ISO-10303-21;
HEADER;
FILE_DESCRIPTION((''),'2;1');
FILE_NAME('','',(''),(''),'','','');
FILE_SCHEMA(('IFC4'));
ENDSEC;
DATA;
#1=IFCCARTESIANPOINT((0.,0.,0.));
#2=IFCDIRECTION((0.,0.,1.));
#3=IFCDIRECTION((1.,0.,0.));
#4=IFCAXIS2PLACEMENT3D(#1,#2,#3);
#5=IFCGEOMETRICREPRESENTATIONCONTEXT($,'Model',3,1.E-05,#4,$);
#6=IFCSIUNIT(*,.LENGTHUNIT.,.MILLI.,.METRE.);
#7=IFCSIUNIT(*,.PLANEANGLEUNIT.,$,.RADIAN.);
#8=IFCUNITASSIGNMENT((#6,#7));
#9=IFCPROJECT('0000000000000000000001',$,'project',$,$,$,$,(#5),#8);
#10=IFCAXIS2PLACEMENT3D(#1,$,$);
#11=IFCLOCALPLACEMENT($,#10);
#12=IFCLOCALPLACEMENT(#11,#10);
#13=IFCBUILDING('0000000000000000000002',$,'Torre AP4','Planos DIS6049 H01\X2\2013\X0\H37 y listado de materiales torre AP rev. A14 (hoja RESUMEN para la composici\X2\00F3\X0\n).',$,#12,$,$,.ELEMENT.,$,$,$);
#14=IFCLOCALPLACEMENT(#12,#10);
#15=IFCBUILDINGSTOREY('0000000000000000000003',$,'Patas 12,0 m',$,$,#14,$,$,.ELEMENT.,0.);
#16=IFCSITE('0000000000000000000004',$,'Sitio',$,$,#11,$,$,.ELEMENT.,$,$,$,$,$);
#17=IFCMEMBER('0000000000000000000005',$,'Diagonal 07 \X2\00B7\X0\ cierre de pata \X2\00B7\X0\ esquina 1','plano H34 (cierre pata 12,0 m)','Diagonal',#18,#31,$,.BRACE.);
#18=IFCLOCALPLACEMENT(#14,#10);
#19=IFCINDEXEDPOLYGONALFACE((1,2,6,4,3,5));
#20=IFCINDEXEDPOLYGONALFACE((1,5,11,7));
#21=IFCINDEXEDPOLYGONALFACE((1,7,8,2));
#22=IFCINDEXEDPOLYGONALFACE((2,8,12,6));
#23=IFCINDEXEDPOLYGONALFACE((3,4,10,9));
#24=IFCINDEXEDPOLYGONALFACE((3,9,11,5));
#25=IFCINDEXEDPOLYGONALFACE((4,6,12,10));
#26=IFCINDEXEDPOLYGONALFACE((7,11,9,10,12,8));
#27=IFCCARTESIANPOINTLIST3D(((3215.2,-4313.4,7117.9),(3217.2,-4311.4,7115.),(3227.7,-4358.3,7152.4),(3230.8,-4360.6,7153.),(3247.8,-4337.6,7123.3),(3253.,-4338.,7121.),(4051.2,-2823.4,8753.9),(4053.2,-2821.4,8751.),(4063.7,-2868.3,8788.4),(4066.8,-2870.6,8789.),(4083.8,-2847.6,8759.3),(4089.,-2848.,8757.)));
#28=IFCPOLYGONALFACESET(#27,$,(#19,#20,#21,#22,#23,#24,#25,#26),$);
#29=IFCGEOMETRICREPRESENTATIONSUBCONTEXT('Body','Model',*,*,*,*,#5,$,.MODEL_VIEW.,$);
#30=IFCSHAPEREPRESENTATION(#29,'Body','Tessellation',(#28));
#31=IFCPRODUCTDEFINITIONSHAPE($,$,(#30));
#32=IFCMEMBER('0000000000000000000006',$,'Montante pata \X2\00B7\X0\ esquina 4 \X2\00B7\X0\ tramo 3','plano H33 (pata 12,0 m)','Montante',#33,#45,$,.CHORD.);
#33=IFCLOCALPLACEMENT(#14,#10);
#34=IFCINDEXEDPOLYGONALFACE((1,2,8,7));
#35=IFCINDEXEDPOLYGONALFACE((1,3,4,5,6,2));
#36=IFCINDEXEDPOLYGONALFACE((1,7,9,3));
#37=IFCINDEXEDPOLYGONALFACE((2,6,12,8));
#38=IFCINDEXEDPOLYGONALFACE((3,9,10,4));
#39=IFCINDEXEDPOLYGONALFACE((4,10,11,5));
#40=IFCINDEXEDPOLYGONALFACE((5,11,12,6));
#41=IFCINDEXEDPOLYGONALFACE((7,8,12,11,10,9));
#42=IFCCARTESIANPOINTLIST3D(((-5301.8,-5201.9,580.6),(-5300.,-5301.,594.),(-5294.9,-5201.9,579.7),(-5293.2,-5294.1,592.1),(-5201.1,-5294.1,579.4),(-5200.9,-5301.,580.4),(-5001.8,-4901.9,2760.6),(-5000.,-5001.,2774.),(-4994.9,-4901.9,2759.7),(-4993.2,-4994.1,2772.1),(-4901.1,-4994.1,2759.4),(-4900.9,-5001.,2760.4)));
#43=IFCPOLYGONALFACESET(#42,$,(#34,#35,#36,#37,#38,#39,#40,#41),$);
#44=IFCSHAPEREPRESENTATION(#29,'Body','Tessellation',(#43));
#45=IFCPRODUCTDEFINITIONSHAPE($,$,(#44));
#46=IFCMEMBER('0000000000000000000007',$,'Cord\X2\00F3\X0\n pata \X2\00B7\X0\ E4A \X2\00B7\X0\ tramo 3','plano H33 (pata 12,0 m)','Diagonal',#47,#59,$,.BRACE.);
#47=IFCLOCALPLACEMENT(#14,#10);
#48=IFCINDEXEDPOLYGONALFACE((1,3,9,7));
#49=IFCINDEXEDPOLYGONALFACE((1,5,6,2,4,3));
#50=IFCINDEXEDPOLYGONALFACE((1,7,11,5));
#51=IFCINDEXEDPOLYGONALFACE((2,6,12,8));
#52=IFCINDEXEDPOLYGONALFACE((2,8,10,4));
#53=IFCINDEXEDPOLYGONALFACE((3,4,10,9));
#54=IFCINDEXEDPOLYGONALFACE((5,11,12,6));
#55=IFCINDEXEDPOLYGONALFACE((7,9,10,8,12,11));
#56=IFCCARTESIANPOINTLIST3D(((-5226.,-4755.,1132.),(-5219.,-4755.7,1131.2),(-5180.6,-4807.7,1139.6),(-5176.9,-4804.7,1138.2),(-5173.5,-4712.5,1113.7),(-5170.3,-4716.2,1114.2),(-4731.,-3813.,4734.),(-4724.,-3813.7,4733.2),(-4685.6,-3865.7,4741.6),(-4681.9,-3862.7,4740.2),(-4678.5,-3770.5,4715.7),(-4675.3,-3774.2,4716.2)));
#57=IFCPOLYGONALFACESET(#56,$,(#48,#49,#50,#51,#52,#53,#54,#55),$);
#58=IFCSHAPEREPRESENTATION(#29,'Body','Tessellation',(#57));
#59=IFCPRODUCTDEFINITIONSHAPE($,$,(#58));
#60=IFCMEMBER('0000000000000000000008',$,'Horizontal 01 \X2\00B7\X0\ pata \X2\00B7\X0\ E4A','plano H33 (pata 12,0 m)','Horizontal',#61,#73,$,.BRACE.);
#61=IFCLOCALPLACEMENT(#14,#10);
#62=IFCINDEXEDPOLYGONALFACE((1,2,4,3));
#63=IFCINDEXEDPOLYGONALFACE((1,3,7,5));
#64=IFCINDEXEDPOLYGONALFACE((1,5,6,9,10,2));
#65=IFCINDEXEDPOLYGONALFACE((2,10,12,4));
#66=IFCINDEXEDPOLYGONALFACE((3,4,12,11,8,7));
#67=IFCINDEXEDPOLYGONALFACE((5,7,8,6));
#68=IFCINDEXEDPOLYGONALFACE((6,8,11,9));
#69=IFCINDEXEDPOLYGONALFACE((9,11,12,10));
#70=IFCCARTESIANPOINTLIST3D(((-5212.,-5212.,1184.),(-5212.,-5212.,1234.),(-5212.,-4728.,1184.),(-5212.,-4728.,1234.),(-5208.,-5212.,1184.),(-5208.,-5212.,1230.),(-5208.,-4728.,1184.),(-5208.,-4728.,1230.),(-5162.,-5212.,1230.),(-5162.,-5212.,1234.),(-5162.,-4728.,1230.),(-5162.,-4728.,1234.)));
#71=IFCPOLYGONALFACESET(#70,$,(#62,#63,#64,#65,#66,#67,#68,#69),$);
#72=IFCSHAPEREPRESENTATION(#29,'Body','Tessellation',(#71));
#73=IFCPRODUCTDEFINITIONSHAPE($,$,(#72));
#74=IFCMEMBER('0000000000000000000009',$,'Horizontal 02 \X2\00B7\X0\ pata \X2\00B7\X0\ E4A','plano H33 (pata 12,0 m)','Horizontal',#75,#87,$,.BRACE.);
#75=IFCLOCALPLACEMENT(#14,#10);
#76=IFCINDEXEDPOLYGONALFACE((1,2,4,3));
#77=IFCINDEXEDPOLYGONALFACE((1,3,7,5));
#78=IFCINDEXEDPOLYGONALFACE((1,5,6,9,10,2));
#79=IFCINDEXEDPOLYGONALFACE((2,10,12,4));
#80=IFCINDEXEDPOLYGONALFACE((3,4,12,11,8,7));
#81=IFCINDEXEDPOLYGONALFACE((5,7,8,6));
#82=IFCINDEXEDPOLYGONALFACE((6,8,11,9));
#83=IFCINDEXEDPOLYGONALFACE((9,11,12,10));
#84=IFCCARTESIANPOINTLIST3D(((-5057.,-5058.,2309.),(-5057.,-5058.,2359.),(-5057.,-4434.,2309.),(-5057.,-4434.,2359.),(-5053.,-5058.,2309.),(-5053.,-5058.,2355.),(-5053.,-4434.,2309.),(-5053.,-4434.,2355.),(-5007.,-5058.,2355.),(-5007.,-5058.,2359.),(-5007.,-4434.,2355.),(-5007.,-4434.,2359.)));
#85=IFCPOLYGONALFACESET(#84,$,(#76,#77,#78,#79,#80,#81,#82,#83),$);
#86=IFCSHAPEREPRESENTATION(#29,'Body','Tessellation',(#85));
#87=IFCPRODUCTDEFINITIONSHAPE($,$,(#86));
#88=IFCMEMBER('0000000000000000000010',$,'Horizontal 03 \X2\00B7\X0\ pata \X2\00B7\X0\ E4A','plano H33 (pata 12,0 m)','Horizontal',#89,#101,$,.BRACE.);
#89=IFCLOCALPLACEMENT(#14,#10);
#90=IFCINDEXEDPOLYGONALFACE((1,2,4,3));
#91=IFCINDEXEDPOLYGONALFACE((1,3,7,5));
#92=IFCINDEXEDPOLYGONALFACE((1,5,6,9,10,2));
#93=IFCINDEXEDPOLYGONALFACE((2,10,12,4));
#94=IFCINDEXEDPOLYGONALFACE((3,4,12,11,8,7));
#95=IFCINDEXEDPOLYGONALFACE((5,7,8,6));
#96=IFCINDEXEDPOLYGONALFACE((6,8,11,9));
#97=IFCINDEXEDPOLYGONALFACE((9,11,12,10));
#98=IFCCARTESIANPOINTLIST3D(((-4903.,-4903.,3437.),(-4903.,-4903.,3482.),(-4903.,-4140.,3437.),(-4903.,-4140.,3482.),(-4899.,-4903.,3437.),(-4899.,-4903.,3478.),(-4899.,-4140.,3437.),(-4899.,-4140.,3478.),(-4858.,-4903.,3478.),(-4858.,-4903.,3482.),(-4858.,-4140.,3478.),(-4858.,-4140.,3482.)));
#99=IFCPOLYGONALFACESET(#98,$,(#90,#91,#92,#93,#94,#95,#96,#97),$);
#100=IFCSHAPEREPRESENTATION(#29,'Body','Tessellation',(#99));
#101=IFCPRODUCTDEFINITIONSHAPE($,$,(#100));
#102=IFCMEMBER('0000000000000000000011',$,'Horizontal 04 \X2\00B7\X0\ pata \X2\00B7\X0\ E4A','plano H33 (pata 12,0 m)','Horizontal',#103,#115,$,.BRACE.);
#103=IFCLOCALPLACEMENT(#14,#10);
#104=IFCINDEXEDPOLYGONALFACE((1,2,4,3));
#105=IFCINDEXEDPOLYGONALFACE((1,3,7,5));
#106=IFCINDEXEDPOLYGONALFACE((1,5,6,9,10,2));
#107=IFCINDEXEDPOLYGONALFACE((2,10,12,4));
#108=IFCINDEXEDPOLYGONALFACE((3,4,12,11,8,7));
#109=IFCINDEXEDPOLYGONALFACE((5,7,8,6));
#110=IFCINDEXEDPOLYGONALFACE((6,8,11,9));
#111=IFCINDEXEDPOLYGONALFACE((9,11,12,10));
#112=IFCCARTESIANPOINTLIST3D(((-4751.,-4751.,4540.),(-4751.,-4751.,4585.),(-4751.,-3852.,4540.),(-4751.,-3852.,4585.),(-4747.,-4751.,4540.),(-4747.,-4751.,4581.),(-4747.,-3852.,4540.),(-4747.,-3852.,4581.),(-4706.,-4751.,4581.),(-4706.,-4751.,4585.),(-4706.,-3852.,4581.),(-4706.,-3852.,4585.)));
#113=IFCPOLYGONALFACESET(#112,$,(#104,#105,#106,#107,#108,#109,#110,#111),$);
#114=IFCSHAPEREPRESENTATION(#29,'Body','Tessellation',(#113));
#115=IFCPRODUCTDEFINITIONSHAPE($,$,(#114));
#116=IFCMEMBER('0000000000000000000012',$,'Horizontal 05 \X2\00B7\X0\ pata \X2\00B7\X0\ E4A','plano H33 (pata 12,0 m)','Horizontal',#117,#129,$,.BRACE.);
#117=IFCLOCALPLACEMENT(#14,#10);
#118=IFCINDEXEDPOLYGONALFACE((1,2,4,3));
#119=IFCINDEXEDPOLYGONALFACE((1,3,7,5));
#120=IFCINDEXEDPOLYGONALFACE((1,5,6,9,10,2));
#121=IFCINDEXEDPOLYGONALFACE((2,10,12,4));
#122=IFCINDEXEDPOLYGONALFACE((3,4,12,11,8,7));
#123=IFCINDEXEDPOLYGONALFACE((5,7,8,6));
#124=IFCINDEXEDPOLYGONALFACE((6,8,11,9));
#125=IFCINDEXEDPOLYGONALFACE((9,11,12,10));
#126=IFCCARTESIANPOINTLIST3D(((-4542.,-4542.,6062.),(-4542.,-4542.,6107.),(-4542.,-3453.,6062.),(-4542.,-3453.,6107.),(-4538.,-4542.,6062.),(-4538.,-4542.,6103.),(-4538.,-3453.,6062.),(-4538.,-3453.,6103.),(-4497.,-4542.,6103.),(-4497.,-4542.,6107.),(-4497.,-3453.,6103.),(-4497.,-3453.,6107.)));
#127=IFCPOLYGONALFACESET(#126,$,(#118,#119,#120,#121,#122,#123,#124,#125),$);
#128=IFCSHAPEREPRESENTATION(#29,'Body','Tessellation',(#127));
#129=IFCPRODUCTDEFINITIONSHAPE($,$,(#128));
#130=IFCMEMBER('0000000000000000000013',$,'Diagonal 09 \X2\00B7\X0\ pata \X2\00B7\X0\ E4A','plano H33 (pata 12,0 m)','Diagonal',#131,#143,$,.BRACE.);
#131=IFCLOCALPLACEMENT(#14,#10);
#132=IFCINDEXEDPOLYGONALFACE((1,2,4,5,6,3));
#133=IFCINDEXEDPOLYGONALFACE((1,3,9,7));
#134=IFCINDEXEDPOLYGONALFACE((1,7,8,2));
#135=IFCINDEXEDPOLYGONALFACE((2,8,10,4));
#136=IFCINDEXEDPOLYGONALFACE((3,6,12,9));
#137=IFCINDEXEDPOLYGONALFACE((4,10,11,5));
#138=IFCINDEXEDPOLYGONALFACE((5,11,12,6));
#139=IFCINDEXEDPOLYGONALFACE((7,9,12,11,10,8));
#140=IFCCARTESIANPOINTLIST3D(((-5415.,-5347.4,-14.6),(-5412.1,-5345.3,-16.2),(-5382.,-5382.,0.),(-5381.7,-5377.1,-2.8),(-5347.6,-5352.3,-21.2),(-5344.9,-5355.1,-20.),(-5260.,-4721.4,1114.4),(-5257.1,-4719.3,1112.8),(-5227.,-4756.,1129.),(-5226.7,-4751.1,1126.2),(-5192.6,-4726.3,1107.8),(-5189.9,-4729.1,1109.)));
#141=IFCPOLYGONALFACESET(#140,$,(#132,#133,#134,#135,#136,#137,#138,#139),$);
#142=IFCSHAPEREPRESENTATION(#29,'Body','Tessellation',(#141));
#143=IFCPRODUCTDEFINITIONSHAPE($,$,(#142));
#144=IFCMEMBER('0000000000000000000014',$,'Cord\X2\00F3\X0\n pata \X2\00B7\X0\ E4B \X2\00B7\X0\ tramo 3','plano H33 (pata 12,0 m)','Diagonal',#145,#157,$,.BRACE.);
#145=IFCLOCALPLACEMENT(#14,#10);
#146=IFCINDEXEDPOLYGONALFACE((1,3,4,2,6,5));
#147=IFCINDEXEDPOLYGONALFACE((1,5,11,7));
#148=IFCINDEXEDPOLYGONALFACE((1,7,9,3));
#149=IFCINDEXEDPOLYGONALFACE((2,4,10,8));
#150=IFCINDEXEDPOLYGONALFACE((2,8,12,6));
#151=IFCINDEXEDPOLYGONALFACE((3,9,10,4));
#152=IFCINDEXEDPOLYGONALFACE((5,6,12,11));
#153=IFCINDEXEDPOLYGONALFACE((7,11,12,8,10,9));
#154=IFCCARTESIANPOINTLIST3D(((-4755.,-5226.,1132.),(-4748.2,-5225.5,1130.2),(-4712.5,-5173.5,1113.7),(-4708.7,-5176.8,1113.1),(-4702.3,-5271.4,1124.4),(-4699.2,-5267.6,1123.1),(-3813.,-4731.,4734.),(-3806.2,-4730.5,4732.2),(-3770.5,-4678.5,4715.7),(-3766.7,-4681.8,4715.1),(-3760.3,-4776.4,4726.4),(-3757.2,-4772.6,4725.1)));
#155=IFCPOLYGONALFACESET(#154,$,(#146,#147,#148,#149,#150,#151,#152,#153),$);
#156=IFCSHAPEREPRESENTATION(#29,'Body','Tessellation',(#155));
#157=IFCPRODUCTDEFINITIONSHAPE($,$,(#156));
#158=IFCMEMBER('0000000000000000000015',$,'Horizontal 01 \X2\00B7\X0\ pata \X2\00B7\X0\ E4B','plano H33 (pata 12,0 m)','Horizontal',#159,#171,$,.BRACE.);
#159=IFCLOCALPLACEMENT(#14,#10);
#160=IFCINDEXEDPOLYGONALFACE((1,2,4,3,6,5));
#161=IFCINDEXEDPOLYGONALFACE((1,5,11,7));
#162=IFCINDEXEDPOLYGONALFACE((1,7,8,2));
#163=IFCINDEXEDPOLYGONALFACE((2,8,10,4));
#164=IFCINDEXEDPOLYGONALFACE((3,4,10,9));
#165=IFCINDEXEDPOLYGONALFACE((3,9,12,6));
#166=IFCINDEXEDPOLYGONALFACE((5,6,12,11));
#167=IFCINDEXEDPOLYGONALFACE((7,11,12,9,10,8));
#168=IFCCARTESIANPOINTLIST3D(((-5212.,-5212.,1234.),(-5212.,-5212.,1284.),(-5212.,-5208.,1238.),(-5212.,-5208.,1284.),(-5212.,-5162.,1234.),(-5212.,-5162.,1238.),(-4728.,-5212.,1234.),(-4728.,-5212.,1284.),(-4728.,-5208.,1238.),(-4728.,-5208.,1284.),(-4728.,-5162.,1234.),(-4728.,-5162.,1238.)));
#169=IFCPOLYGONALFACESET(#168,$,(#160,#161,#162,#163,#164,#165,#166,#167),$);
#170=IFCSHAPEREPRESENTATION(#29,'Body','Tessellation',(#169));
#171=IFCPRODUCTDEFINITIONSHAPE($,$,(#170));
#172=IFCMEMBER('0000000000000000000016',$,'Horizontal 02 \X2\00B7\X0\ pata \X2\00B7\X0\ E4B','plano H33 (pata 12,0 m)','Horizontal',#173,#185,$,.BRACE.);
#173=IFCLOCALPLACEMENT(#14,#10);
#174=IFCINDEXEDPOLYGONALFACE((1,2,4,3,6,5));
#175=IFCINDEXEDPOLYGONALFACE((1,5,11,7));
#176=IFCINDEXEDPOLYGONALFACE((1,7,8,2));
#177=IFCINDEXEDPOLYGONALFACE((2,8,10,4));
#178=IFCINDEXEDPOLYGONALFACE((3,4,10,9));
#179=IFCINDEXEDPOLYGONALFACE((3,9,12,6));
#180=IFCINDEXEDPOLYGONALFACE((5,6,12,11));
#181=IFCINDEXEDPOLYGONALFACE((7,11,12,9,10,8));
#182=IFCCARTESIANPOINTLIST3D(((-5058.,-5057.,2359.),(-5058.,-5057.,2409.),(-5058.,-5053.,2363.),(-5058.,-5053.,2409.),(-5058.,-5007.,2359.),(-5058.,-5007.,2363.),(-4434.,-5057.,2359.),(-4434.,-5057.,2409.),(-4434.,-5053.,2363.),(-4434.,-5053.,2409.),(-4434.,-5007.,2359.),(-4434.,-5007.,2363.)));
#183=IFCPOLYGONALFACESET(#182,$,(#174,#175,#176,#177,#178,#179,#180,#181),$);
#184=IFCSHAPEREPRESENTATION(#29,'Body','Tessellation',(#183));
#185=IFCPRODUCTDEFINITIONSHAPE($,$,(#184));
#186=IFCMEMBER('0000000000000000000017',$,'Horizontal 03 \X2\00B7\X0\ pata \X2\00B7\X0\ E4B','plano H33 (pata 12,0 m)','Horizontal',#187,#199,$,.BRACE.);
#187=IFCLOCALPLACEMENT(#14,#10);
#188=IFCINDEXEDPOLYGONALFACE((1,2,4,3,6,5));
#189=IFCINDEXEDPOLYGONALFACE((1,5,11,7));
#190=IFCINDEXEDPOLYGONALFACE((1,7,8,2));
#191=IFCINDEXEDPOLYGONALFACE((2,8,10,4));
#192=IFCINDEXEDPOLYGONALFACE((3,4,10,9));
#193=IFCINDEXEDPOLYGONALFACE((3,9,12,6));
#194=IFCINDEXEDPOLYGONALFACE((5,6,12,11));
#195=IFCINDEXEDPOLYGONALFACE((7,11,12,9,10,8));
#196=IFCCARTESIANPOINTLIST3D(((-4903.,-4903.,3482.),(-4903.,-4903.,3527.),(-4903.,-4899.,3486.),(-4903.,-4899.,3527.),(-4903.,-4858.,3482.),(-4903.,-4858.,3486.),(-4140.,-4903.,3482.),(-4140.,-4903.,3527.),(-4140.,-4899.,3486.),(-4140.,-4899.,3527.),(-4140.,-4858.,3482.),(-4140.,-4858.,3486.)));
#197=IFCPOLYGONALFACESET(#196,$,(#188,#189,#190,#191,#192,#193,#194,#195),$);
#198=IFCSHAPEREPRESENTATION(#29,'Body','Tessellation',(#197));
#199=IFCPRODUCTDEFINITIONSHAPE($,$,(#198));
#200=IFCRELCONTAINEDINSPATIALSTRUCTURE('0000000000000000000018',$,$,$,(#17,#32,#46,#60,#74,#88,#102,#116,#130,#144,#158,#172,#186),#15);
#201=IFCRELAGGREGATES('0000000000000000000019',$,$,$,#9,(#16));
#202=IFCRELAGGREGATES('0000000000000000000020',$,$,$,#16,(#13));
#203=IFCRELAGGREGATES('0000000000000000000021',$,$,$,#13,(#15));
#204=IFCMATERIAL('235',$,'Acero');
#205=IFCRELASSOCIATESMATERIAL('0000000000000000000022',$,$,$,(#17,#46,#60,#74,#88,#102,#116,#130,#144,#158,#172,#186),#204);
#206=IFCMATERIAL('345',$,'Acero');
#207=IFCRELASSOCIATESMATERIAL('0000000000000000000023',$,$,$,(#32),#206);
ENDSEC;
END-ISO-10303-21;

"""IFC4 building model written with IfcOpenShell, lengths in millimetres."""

from ifc_helpers import new_model, si_unit, frame, frame_2d, origin, origin_with_axes, place, context, subcontext, project, spatial, l_section, extrude, material, element, save


model = new_model("IFC4")

# Units and contexts
model_context = context("Model", 3, precision=1e-05, world=origin_with_axes())
body_context = subcontext(model_context, "Body", "Model", "MODEL_VIEW")
ifc_project = project(units=[si_unit("LENGTHUNIT", "METRE", prefix="MILLI"), si_unit("PLANEANGLEUNIT", "RADIAN")], contexts=[model_context])

# Site, building, storey
site_placement = place(None, origin())
site = spatial("IfcSite", under=ifc_project, at=site_placement, Name="Sitio", CompositionType="ELEMENT")
building_placement = place(site_placement, origin())
building = spatial("IfcBuilding", under=site, at=building_placement, Name="Torre AP4", Description="Planos DIS6049 H01–H37 y listado de materiales torre AP rev. A14 (hoja RESUMEN para la composición).", CompositionType="ELEMENT")
storey_placement = place(building_placement, origin())
storey = spatial("IfcBuildingStorey", under=building, at=storey_placement, Name="Patas 12,0 m", CompositionType="ELEMENT", Elevation=0.0)

# Members
ifc_material_1 = material(Name="235", Category="Acero")
member_1_placement = place(storey_placement, frame((3253.0, -4338.0, 7121.0), z_axis=(0.353417, 0.629894, 0.691615), x_axis=(-0.795293, 0.591591, -0.1324)))
element("IfcMember", 1, at=member_1_placement, inside=storey, material=ifc_material_1, Name="Diagonal 07 · cierre de pata · esquina 1", Description="plano H34 (cierre pata 12,0 m)", ObjectType="Diagonal", PredefinedType="BRACE", context=body_context, shape_type="SweptSolid", body=[
    extrude(l_section(Depth=45.0, Width=45.0, Thickness=4.0, at=frame_2d((22.5, 22.5))), None, (0.0, 0.0, 1.0), 2365.5),
])
ifc_material_2 = material(Name="345", Category="Acero")
member_2_placement = place(storey_placement, frame((-5000.0, -5001.0, 2774.0), z_axis=(-0.13508, -0.13508, -0.981584), x_axis=(-0.018415, 0.990835, -0.133819)))
element("IfcMember", 2, at=member_2_placement, inside=storey, material=ifc_material_2, Name="Montante pata · esquina 4 · tramo 3", Description="plano H33 (pata 12,0 m)", ObjectType="Montante", PredefinedType="CHORD", context=body_context, shape_type="SweptSolid", body=[
    extrude(l_section(Depth=100.0, Width=100.0, Thickness=7.0, at=frame_2d((50.0, 50.0))), None, (0.0, 0.0, 1.0), 2220.9),
])
member_3_placement = place(storey_placement, frame((-4731.0, -3813.0, 4734.0), z_axis=(-0.131793, -0.250805, -0.959024), x_axis=(0.749767, 0.607646, -0.261948)))
element("IfcMember", 3, at=member_3_placement, inside=storey, material=ifc_material_1, Name="Cordón pata · E4A · tramo 3", Description="plano H33 (pata 12,0 m)", ObjectType="Diagonal", PredefinedType="BRACE", context=body_context, shape_type="SweptSolid", body=[
    extrude(l_section(Depth=70.0, Width=70.0, Thickness=5.0, at=frame_2d((35.0, 35.0))), None, (0.0, 0.0, 1.0), 3755.9),
])
member_4_placement = place(storey_placement, frame((-5212.0, -5212.0, 1234.0), z_axis=(0.0, 1.0, 0.0), x_axis=(1.0, 0.0, 0.0)))
element("IfcMember", 4, at=member_4_placement, inside=storey, material=ifc_material_1, Name="Horizontal 01 · pata · E4A", Description="plano H33 (pata 12,0 m)", ObjectType="Horizontal", PredefinedType="BRACE", context=body_context, shape_type="SweptSolid", body=[
    extrude(l_section(Depth=50.0, Width=50.0, Thickness=4.0, at=frame_2d((25.0, 25.0))), None, (0.0, 0.0, 1.0), 484.0),
])
member_5_placement = place(storey_placement, frame((-5057.0, -5058.0, 2359.0), z_axis=(0.0, 1.0, 0.0), x_axis=(1.0, 0.0, 0.0)))
element("IfcMember", 5, at=member_5_placement, inside=storey, material=ifc_material_1, Name="Horizontal 02 · pata · E4A", Description="plano H33 (pata 12,0 m)", ObjectType="Horizontal", PredefinedType="BRACE", context=body_context, shape_type="SweptSolid", body=[
    extrude(l_section(Depth=50.0, Width=50.0, Thickness=4.0, at=frame_2d((25.0, 25.0))), None, (0.0, 0.0, 1.0), 624.0),
])
member_6_placement = place(storey_placement, frame((-4903.0, -4903.0, 3482.0), z_axis=(0.0, 1.0, 0.0), x_axis=(1.0, 0.0, 0.0)))
element("IfcMember", 6, at=member_6_placement, inside=storey, material=ifc_material_1, Name="Horizontal 03 · pata · E4A", Description="plano H33 (pata 12,0 m)", ObjectType="Horizontal", PredefinedType="BRACE", context=body_context, shape_type="SweptSolid", body=[
    extrude(l_section(Depth=45.0, Width=45.0, Thickness=4.0, at=frame_2d((22.5, 22.5))), None, (0.0, 0.0, 1.0), 763.0),
])
member_7_placement = place(storey_placement, frame((-4751.0, -4751.0, 4585.0), z_axis=(0.0, 1.0, 0.0), x_axis=(1.0, 0.0, 0.0)))
element("IfcMember", 7, at=member_7_placement, inside=storey, material=ifc_material_1, Name="Horizontal 04 · pata · E4A", Description="plano H33 (pata 12,0 m)", ObjectType="Horizontal", PredefinedType="BRACE", context=body_context, shape_type="SweptSolid", body=[
    extrude(l_section(Depth=45.0, Width=45.0, Thickness=4.0, at=frame_2d((22.5, 22.5))), None, (0.0, 0.0, 1.0), 899.0),
])
member_8_placement = place(storey_placement, frame((-4542.0, -4542.0, 6107.0), z_axis=(0.0, 1.0, 0.0), x_axis=(1.0, 0.0, 0.0)))
element("IfcMember", 8, at=member_8_placement, inside=storey, material=ifc_material_1, Name="Horizontal 05 · pata · E4A", Description="plano H33 (pata 12,0 m)", ObjectType="Horizontal", PredefinedType="BRACE", context=body_context, shape_type="SweptSolid", body=[
    extrude(l_section(Depth=45.0, Width=45.0, Thickness=4.0, at=frame_2d((22.5, 22.5))), None, (0.0, 0.0, 1.0), 1089.0),
])
member_9_placement = place(storey_placement, frame((-5382.0, -5382.0, 0.0), z_axis=(0.119212, 0.481461, 0.868322), x_axis=(0.741182, 0.53876, -0.400484)))
element("IfcMember", 9, at=member_9_placement, inside=storey, material=ifc_material_1, Name="Diagonal 09 · pata · E4A", Description="plano H33 (pata 12,0 m)", ObjectType="Diagonal", PredefinedType="BRACE", context=body_context, shape_type="SweptSolid", body=[
    extrude(l_section(Depth=50.0, Width=50.0, Thickness=4.0, at=frame_2d((25.0, 25.0))), None, (0.0, 0.0, 1.0), 1300.2),
])
member_10_placement = place(storey_placement, frame((-3813.0, -4731.0, 4734.0), z_axis=(-0.250805, -0.131793, -0.959024), x_axis=(0.607646, 0.749767, -0.261948)))
element("IfcMember", 10, at=member_10_placement, inside=storey, material=ifc_material_1, Name="Cordón pata · E4B · tramo 3", Description="plano H33 (pata 12,0 m)", ObjectType="Diagonal", PredefinedType="BRACE", context=body_context, shape_type="SweptSolid", body=[
    extrude(l_section(Depth=70.0, Width=70.0, Thickness=5.0, at=frame_2d((35.0, 35.0))), None, (0.0, 0.0, 1.0), 3755.9),
])
member_11_placement = place(storey_placement, frame((-5212.0, -5212.0, 1234.0), z_axis=(1.0, 0.0, 0.0), x_axis=(0.0, 1.0, 0.0)))
element("IfcMember", 11, at=member_11_placement, inside=storey, material=ifc_material_1, Name="Horizontal 01 · pata · E4B", Description="plano H33 (pata 12,0 m)", ObjectType="Horizontal", PredefinedType="BRACE", context=body_context, shape_type="SweptSolid", body=[
    extrude(l_section(Depth=50.0, Width=50.0, Thickness=4.0, at=frame_2d((25.0, 25.0))), None, (0.0, 0.0, 1.0), 484.0),
])
member_12_placement = place(storey_placement, frame((-5058.0, -5057.0, 2359.0), z_axis=(1.0, 0.0, 0.0), x_axis=(0.0, 1.0, 0.0)))
element("IfcMember", 12, at=member_12_placement, inside=storey, material=ifc_material_1, Name="Horizontal 02 · pata · E4B", Description="plano H33 (pata 12,0 m)", ObjectType="Horizontal", PredefinedType="BRACE", context=body_context, shape_type="SweptSolid", body=[
    extrude(l_section(Depth=50.0, Width=50.0, Thickness=4.0, at=frame_2d((25.0, 25.0))), None, (0.0, 0.0, 1.0), 624.0),
])
member_13_placement = place(storey_placement, frame((-4903.0, -4903.0, 3482.0), z_axis=(1.0, 0.0, 0.0), x_axis=(0.0, 1.0, 0.0)))
element("IfcMember", 13, at=member_13_placement, inside=storey, material=ifc_material_1, Name="Horizontal 03 · pata · E4B", Description="plano H33 (pata 12,0 m)", ObjectType="Horizontal", PredefinedType="BRACE", context=body_context, shape_type="SweptSolid", body=[
    extrude(l_section(Depth=45.0, Width=45.0, Thickness=4.0, at=frame_2d((22.5, 22.5))), None, (0.0, 0.0, 1.0), 763.0),
])

save(model, "model.ifc")
